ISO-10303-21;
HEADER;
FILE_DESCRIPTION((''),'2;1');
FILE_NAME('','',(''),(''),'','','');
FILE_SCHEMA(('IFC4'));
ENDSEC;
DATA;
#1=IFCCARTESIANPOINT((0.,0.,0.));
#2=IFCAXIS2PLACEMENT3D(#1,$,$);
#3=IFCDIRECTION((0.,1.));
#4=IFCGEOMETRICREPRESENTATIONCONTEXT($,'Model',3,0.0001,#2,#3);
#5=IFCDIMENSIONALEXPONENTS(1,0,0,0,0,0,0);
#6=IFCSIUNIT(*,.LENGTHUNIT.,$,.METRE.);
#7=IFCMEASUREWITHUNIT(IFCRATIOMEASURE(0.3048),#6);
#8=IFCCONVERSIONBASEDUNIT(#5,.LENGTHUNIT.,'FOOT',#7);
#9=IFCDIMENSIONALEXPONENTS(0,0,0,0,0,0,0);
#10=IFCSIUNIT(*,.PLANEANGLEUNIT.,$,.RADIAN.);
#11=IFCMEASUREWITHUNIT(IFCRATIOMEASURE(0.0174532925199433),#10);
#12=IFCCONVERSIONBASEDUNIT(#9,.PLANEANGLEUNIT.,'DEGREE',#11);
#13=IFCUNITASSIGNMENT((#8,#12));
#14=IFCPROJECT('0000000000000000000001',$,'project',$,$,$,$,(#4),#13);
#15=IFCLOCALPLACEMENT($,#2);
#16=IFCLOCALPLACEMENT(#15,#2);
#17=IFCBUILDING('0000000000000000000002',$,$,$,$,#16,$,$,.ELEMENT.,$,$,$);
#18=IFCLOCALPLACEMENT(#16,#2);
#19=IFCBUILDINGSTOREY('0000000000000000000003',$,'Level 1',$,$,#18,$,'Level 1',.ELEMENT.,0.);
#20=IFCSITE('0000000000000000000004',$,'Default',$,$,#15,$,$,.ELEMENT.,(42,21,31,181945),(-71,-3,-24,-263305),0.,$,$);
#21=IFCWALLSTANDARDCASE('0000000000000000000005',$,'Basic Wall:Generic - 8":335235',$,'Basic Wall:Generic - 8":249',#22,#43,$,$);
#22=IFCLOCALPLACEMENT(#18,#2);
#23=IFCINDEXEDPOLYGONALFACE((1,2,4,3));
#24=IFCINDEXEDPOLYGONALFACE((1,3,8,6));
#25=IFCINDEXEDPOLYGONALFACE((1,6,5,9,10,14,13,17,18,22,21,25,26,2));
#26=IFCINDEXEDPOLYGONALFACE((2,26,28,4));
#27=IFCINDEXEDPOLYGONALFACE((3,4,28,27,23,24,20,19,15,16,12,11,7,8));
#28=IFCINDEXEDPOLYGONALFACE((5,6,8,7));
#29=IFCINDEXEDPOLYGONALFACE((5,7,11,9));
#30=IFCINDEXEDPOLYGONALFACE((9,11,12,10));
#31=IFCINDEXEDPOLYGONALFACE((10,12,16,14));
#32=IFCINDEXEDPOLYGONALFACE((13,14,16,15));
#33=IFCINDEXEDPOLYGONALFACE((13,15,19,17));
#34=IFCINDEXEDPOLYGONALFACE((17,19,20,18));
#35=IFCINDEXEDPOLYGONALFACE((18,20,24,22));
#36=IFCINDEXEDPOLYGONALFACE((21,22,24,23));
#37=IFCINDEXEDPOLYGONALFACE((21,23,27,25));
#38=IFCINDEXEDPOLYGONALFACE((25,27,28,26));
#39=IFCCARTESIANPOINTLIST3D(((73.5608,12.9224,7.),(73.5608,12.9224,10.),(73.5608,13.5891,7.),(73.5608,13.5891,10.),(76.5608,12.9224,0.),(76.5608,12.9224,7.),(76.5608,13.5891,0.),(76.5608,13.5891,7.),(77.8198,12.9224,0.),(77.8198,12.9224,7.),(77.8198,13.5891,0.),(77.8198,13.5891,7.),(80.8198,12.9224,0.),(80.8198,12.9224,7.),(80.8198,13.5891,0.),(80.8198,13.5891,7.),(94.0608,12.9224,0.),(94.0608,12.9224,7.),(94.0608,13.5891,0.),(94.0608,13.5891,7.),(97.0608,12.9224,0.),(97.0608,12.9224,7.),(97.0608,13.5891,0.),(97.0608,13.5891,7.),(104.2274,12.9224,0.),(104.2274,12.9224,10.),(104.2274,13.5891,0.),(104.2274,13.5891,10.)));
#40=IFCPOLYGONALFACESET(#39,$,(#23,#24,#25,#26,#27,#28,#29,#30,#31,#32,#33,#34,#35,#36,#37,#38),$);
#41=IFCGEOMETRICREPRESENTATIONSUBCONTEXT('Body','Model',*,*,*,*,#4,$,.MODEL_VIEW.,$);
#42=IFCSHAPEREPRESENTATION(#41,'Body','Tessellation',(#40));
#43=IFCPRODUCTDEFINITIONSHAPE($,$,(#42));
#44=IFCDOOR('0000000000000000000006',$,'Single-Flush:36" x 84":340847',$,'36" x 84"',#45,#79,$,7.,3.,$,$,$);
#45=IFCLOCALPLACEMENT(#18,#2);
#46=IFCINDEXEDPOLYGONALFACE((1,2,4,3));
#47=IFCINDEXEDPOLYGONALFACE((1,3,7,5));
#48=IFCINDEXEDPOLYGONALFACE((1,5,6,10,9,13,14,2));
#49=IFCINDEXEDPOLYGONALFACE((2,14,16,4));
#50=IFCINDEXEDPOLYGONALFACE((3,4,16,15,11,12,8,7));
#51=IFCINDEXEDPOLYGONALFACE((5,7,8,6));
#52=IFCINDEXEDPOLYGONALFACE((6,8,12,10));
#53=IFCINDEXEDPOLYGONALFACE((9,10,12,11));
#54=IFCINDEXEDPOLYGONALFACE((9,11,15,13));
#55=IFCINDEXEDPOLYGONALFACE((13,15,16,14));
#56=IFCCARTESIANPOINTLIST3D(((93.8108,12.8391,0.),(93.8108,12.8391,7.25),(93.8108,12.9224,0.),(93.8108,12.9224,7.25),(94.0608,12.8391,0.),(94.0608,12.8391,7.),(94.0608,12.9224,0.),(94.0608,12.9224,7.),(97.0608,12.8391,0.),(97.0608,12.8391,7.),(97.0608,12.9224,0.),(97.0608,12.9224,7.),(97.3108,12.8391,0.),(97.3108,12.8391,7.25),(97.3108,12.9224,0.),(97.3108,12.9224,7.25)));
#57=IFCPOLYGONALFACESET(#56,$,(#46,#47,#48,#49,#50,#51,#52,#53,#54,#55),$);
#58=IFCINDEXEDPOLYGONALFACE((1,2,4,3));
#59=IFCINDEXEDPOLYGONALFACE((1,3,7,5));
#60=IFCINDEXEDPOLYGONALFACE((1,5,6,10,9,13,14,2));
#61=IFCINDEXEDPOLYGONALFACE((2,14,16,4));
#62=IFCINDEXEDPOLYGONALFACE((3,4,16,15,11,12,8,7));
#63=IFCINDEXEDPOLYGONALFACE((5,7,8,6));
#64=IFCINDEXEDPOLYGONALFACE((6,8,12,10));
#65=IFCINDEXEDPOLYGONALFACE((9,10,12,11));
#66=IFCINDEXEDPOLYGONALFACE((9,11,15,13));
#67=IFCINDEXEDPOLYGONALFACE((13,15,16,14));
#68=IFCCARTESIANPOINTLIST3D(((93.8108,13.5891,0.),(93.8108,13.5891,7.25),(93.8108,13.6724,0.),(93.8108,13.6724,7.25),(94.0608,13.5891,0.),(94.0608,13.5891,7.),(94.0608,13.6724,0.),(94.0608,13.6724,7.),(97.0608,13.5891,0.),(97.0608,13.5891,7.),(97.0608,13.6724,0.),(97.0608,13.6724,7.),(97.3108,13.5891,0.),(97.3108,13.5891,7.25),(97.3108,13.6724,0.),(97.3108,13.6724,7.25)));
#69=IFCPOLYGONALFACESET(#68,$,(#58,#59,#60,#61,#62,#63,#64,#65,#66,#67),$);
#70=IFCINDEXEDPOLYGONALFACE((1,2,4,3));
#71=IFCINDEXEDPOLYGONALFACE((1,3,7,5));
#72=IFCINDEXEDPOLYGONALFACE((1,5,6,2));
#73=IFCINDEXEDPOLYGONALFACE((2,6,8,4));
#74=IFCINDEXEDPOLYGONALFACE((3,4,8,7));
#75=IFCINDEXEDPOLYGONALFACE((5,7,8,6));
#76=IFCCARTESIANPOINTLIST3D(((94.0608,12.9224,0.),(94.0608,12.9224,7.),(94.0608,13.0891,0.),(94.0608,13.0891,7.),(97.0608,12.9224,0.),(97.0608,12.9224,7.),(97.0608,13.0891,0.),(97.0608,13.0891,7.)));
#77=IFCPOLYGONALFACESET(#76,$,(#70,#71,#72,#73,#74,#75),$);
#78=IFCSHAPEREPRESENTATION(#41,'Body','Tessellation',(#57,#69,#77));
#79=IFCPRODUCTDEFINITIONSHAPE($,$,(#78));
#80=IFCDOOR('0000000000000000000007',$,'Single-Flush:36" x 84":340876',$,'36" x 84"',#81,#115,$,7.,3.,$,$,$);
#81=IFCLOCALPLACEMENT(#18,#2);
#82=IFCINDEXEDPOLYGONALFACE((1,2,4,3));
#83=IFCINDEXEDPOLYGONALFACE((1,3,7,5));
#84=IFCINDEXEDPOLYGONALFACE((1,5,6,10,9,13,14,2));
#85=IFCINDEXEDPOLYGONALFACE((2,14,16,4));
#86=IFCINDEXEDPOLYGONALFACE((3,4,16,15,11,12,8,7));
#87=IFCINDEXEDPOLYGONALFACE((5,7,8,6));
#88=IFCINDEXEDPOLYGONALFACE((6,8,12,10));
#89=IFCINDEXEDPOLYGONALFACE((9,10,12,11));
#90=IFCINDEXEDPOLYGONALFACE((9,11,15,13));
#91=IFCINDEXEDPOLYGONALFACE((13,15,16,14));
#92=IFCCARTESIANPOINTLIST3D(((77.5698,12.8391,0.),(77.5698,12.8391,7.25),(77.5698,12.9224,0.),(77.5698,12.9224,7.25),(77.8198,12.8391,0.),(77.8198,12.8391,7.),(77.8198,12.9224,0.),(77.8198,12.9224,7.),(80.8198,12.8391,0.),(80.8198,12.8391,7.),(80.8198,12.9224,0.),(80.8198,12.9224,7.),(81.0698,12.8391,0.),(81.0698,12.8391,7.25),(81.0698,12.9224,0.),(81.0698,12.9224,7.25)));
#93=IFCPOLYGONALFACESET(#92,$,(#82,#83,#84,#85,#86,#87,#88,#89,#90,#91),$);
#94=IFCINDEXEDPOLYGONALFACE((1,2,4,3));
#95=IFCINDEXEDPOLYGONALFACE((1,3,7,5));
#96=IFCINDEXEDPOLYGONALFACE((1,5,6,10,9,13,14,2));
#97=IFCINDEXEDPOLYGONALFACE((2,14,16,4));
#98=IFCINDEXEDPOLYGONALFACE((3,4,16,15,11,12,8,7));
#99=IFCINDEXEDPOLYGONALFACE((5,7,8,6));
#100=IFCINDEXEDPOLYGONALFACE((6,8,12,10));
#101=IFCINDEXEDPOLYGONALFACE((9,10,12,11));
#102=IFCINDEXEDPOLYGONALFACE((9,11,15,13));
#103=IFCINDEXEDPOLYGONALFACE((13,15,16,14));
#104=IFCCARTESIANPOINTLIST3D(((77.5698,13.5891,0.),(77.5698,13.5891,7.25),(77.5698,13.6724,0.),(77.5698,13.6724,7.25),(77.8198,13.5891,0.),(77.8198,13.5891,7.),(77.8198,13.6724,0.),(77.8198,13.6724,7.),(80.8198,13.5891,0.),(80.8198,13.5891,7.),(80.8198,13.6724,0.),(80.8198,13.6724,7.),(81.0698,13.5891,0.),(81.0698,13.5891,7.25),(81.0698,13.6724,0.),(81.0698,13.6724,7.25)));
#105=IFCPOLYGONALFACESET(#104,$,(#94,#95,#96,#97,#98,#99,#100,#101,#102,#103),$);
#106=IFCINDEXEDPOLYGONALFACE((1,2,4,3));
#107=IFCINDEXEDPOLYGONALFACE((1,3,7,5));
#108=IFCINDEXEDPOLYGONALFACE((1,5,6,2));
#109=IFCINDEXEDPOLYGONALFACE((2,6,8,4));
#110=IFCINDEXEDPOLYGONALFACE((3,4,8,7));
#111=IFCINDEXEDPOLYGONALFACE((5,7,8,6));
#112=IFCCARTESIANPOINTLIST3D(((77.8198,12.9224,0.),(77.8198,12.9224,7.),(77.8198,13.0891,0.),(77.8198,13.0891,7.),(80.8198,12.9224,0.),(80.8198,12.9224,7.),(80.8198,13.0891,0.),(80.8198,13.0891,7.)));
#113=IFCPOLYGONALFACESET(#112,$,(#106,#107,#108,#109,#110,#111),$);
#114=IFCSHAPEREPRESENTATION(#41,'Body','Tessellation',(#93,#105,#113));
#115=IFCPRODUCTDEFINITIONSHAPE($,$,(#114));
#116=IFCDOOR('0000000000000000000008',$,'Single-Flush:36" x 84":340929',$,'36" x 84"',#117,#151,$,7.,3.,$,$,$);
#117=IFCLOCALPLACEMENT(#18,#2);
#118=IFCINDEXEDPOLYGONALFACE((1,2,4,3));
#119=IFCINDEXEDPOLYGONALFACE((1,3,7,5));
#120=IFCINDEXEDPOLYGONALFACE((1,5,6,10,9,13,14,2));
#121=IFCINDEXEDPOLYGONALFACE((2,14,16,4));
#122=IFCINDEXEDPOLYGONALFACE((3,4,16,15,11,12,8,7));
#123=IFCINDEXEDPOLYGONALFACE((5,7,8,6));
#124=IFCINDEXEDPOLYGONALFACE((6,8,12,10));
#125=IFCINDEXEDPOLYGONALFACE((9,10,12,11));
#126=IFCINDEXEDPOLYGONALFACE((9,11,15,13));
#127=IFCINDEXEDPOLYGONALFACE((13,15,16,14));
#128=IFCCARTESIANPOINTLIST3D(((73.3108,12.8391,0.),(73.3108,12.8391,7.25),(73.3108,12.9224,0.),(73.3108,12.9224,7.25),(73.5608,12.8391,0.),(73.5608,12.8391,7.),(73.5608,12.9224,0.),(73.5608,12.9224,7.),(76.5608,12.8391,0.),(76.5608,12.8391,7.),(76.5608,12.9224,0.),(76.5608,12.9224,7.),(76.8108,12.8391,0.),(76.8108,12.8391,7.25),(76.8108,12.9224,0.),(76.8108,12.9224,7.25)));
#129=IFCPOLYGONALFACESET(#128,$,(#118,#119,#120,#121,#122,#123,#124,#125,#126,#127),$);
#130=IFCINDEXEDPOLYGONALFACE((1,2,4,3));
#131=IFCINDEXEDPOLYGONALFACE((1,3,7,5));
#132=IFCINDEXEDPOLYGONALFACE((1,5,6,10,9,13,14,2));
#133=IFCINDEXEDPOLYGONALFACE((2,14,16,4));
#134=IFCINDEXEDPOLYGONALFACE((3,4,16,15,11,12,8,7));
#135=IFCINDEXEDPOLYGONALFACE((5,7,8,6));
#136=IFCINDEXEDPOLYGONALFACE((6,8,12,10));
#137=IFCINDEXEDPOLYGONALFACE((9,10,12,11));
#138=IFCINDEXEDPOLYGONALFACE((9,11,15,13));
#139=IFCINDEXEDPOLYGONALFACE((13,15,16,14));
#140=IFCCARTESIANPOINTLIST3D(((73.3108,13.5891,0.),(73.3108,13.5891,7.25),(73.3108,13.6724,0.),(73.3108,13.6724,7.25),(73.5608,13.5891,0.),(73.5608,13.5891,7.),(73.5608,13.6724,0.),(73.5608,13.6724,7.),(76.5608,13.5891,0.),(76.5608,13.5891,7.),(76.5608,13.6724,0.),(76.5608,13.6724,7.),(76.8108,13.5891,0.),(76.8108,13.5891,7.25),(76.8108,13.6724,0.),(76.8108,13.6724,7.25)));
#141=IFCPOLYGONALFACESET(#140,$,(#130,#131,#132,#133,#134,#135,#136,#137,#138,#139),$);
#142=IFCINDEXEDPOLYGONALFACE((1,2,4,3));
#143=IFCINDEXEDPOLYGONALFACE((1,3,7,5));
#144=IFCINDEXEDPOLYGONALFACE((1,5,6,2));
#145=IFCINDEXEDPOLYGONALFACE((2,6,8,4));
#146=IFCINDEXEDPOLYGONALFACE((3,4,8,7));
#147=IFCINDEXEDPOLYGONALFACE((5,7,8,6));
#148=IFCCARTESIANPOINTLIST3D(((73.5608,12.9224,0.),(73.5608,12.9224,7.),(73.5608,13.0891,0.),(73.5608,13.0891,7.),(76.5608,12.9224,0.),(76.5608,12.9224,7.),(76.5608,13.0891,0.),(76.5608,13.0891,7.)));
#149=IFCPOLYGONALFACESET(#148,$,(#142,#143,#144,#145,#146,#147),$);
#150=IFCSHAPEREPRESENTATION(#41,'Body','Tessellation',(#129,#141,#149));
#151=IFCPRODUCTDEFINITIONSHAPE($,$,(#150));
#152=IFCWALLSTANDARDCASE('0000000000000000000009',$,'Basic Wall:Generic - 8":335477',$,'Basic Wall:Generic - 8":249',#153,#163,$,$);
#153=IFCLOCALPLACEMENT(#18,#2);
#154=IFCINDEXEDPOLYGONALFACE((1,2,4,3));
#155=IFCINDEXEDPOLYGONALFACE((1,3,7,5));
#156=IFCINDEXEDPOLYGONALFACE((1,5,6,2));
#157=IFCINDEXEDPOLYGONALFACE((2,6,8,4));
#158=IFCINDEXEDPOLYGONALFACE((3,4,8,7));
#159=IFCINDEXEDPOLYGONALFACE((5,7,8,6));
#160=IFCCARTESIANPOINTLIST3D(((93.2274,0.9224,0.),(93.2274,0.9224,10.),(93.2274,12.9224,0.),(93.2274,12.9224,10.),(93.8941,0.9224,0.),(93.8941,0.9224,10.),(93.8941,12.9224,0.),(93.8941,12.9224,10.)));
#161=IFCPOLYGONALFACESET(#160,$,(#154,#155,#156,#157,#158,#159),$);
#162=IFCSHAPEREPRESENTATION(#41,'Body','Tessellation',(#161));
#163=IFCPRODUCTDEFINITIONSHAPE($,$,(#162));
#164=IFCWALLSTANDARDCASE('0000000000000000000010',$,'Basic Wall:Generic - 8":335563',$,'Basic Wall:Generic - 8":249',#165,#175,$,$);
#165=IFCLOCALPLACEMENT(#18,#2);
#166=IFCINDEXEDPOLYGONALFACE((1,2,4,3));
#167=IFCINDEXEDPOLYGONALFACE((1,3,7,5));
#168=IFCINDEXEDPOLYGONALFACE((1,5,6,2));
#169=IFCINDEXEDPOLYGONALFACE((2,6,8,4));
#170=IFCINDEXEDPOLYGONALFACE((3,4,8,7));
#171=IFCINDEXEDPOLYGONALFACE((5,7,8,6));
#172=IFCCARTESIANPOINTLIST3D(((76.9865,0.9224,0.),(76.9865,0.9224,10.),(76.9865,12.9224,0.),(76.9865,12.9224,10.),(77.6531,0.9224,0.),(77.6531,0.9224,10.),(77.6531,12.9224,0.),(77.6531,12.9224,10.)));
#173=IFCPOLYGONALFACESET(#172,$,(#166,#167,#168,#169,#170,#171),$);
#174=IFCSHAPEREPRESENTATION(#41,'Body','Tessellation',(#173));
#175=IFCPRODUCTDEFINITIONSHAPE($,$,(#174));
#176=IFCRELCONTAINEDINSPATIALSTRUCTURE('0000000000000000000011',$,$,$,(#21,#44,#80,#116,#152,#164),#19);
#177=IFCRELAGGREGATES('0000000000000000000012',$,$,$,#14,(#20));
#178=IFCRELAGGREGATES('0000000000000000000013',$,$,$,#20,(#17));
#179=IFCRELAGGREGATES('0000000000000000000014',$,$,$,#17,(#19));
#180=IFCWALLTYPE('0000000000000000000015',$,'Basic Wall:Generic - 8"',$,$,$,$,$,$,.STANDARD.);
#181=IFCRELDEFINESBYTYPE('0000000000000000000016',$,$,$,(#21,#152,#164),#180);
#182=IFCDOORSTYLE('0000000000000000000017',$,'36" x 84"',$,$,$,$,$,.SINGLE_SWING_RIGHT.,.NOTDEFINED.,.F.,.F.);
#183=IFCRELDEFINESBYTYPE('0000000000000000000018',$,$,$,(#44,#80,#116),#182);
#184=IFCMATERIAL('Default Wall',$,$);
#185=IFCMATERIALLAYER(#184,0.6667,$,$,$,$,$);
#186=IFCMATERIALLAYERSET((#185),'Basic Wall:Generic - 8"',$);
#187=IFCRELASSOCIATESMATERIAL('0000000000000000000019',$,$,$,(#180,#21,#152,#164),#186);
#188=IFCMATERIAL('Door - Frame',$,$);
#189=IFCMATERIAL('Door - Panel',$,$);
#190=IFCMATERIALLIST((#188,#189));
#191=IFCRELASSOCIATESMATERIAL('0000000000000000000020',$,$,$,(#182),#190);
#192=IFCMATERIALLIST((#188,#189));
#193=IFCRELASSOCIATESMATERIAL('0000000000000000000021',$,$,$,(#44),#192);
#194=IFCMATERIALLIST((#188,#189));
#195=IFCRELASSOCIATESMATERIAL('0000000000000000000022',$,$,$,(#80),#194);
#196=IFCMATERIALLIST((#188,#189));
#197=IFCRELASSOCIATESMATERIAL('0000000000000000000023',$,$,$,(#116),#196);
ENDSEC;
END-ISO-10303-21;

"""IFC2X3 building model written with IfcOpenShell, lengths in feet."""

from ifc_helpers import new_model, entity, si_unit, converted_unit, direction, frame, frame_2d, origin, place, context, subcontext, project, spatial, polyline, rectangle, outline, extrude, source, transform, mapped, material, material_list, layer, layer_set, layer_usage, type_object, type_shapes, element, fill, save


model = new_model("IFC2X3")

# Units and contexts
model_context = context("Model", 3, precision=0.0001, world=origin(), true_north=direction((0.0, 1.0)))
body_context = subcontext(model_context, "Body", "Model", "MODEL_VIEW")
ifc_project = project(units=[converted_unit("LENGTHUNIT", "FOOT", entity("IfcRatioMeasure", 0.3048), si_unit("LENGTHUNIT", "METRE"), dimensions=[1, 0, 0, 0, 0, 0, 0]), converted_unit("PLANEANGLEUNIT", "DEGREE", entity("IfcRatioMeasure", 0.0174532925199433), si_unit("PLANEANGLEUNIT", "RADIAN"), dimensions=[0, 0, 0, 0, 0, 0, 0])], contexts=[model_context])

# Site, building, storey
site_placement = place(None, origin())
site = spatial("IfcSite", under=ifc_project, at=site_placement, Name="Default", CompositionType="ELEMENT", RefLatitude=(42, 21, 31, 181945), RefLongitude=(-71, -3, -24, -263305), RefElevation=0.0)
building_placement = place(site_placement, origin())
building = spatial("IfcBuilding", under=site, at=building_placement, CompositionType="ELEMENT")
storey_placement = place(building_placement, origin())
storey = spatial("IfcBuildingStorey", under=building, at=storey_placement, Name="Level 1", LongName="Level 1", CompositionType="ELEMENT", Elevation=0.0)

# Shared definitions
ifc_material_1 = material(Name="Default Wall")
ifc_layer = layer(ifc_material_1, 0.6667)
ifc_layer_set = layer_set([ifc_layer], Name="Basic Wall:Generic - 8\"")
wall_type = type_object("IfcWallType", Name="Basic Wall:Generic - 8\"", PredefinedType="STANDARD", material=ifc_layer_set)
ifc_material_2 = material(Name="Door - Frame")
ifc_material_3 = material(Name="Door - Panel")
ifc_material_list_1 = material_list([ifc_material_2, ifc_material_3])
door_style = type_object("IfcDoorStyle", Name="36\" x 84\"", ConstructionType="NOTDEFINED", OperationType="SINGLE_SWING_RIGHT", ParameterTakesPrecedence=False, Sizeable=False, material=ifc_material_list_1)
shared_shape = source(origin(), body_context, "Body", "SweptSolid", [
    extrude(outline(polyline([(-1.75, -3.6875), (1.75, -3.6875), (1.75, 3.5625), (1.5, 3.5625), (1.5, -3.4375), (-1.5, -3.4375), (-1.5, 3.5625), (-1.75, 3.5625), (-1.75, -3.6875)])), frame((1.5, 0.6667, 3.5625), z_axis=(0.0, 1.0, 0.0), x_axis=(1.0, 0.0, 0.0)), (0.0, 0.0, 1.0), 0.0833),
    extrude(outline(polyline([(-3.6875, -1.75), (3.5625, -1.75), (3.5625, -1.5), (-3.4375, -1.5), (-3.4375, 1.5), (3.5625, 1.5), (3.5625, 1.75), (-3.6875, 1.75), (-3.6875, -1.75)])), frame((1.5, -0.0833, 3.5625), z_axis=(0.0, 1.0, 0.0), x_axis=(0.0, 0.0, -1.0)), (0.0, 0.0, 1.0), 0.0833),
    extrude(rectangle(XDim=0.1667, YDim=3.0, at=frame_2d((0.0, 0.0), x_axis=(1.0, 0.0))), frame((1.5, 0.5833, 0.0), z_axis=(0.0, 0.0, 1.0), x_axis=(0.0, 1.0, 0.0)), (0.0, 0.0, 1.0), 7.0),
])
type_shapes(door_style, [shared_shape])

# Wall, openings, doors
ifc_layer_usage_1 = layer_usage(ifc_layer_set, "AXIS2", "NEGATIVE", 0.3333)
wall_1_placement = place(storey_placement, frame((104.2274, 13.2558, 0.0), z_axis=(0.0, 0.0, 1.0), x_axis=(-1.0, 0.0, 0.0)))
wall_1 = element("IfcWallStandardCase", 1, at=wall_1_placement, inside=storey, type_object=wall_type, material=ifc_layer_usage_1, Name="Basic Wall:Generic - 8\":335235", ObjectType="Basic Wall:Generic - 8\":249", context=body_context, shape_type="SweptSolid", body=[
    extrude(rectangle(XDim=30.6667, YDim=0.6667, at=frame_2d((15.3333, 0.0), x_axis=(-1.0, 0.0))), origin(), (0.0, 0.0, 1.0), 10.0),
])
opening_1_placement = place(wall_1_placement, frame((7.1667, -0.3333, 0.0)))
opening_1 = element("IfcOpeningElement", 2, at=opening_1_placement, cuts=wall_1, ObjectType="Opening", context=body_context, shape_type="SweptSolid", body=[
    extrude(rectangle(XDim=3.0, YDim=7.0, at=frame_2d((3.5, 1.5), x_axis=(0.0, 1.0))), frame((0.0, 0.0, 0.0), z_axis=(0.0, 1.0, 0.0), x_axis=(0.0, 0.0, 1.0)), (0.0, 0.0, 1.0), 0.6667),
])
opening_2_placement = place(wall_1_placement, frame((23.4076, -0.3333, 0.0)))
opening_2 = element("IfcOpeningElement", 3, at=opening_2_placement, cuts=wall_1, ObjectType="Opening", context=body_context, shape_type="SweptSolid", body=[
    extrude(rectangle(XDim=3.0, YDim=7.0, at=frame_2d((3.5, 1.5), x_axis=(0.0, 1.0))), frame((0.0, 0.0, 0.0), z_axis=(0.0, 1.0, 0.0), x_axis=(0.0, 0.0, 1.0)), (0.0, 0.0, 1.0), 0.6667),
])
opening_3_placement = place(wall_1_placement, frame((27.6667, -0.3333, 0.0)))
opening_3 = element("IfcOpeningElement", 4, at=opening_3_placement, cuts=wall_1, ObjectType="Opening", context=body_context, shape_type="SweptSolid", body=[
    extrude(rectangle(XDim=3.0, YDim=7.0, at=frame_2d((3.5, 1.5), x_axis=(0.0, 1.0))), frame((0.0, 0.0, 0.0), z_axis=(0.0, 1.0, 0.0), x_axis=(0.0, 0.0, 1.0)), (0.0, 0.0, 1.0), 0.6667),
])
ifc_material_list_2 = material_list([ifc_material_2, ifc_material_3])
door_1_placement = place(opening_1_placement, origin())
door_1 = element("IfcDoor", 5, at=door_1_placement, inside=storey, type_object=door_style, material=ifc_material_list_2, Name="Single-Flush:36\" x 84\":340847", ObjectType="36\" x 84\"", OverallHeight=7.0, OverallWidth=3.0, context=body_context, shape_type="MappedRepresentation", body=[
    mapped(shared_shape, transform((0.0, 0.0, 0.0), scale=1.0)),
])
fill(opening_1, door_1)
ifc_material_list_3 = material_list([ifc_material_2, ifc_material_3])
door_2_placement = place(opening_2_placement, origin())
door_2 = element("IfcDoor", 6, at=door_2_placement, inside=storey, type_object=door_style, material=ifc_material_list_3, Name="Single-Flush:36\" x 84\":340876", ObjectType="36\" x 84\"", OverallHeight=7.0, OverallWidth=3.0, context=body_context, shape_type="MappedRepresentation", body=[
    mapped(shared_shape, transform((0.0, 0.0, 0.0), scale=1.0)),
])
fill(opening_2, door_2)
ifc_material_list_4 = material_list([ifc_material_2, ifc_material_3])
door_3_placement = place(opening_3_placement, origin())
door_3 = element("IfcDoor", 7, at=door_3_placement, inside=storey, type_object=door_style, material=ifc_material_list_4, Name="Single-Flush:36\" x 84\":340929", ObjectType="36\" x 84\"", OverallHeight=7.0, OverallWidth=3.0, context=body_context, shape_type="MappedRepresentation", body=[
    mapped(shared_shape, transform((0.0, 0.0, 0.0), scale=1.0)),
])
fill(opening_3, door_3)

# Walls
ifc_layer_usage_2 = layer_usage(ifc_layer_set, "AXIS2", "NEGATIVE", 0.3333)
wall_2_placement = place(storey_placement, frame((93.5608, 12.9224, 0.0), z_axis=(0.0, 0.0, 1.0), x_axis=(0.0, -1.0, 0.0)))
element("IfcWallStandardCase", 8, at=wall_2_placement, inside=storey, type_object=wall_type, material=ifc_layer_usage_2, Name="Basic Wall:Generic - 8\":335477", ObjectType="Basic Wall:Generic - 8\":249", context=body_context, shape_type="SweptSolid", body=[
    extrude(rectangle(XDim=12.0, YDim=0.6667, at=frame_2d((6.0, 0.0), x_axis=(-1.0, 0.0))), origin(), (0.0, 0.0, 1.0), 10.0),
])
ifc_layer_usage_3 = layer_usage(ifc_layer_set, "AXIS2", "NEGATIVE", 0.3333)
wall_3_placement = place(storey_placement, frame((77.3198, 12.9224, 0.0), z_axis=(0.0, 0.0, 1.0), x_axis=(0.0, -1.0, 0.0)))
element("IfcWallStandardCase", 9, at=wall_3_placement, inside=storey, type_object=wall_type, material=ifc_layer_usage_3, Name="Basic Wall:Generic - 8\":335563", ObjectType="Basic Wall:Generic - 8\":249", context=body_context, shape_type="SweptSolid", body=[
    extrude(rectangle(XDim=12.0, YDim=0.6667, at=frame_2d((6.0, 0.0), x_axis=(-1.0, 0.0))), origin(), (0.0, 0.0, 1.0), 10.0),
])

save(model, "model.ifc")
